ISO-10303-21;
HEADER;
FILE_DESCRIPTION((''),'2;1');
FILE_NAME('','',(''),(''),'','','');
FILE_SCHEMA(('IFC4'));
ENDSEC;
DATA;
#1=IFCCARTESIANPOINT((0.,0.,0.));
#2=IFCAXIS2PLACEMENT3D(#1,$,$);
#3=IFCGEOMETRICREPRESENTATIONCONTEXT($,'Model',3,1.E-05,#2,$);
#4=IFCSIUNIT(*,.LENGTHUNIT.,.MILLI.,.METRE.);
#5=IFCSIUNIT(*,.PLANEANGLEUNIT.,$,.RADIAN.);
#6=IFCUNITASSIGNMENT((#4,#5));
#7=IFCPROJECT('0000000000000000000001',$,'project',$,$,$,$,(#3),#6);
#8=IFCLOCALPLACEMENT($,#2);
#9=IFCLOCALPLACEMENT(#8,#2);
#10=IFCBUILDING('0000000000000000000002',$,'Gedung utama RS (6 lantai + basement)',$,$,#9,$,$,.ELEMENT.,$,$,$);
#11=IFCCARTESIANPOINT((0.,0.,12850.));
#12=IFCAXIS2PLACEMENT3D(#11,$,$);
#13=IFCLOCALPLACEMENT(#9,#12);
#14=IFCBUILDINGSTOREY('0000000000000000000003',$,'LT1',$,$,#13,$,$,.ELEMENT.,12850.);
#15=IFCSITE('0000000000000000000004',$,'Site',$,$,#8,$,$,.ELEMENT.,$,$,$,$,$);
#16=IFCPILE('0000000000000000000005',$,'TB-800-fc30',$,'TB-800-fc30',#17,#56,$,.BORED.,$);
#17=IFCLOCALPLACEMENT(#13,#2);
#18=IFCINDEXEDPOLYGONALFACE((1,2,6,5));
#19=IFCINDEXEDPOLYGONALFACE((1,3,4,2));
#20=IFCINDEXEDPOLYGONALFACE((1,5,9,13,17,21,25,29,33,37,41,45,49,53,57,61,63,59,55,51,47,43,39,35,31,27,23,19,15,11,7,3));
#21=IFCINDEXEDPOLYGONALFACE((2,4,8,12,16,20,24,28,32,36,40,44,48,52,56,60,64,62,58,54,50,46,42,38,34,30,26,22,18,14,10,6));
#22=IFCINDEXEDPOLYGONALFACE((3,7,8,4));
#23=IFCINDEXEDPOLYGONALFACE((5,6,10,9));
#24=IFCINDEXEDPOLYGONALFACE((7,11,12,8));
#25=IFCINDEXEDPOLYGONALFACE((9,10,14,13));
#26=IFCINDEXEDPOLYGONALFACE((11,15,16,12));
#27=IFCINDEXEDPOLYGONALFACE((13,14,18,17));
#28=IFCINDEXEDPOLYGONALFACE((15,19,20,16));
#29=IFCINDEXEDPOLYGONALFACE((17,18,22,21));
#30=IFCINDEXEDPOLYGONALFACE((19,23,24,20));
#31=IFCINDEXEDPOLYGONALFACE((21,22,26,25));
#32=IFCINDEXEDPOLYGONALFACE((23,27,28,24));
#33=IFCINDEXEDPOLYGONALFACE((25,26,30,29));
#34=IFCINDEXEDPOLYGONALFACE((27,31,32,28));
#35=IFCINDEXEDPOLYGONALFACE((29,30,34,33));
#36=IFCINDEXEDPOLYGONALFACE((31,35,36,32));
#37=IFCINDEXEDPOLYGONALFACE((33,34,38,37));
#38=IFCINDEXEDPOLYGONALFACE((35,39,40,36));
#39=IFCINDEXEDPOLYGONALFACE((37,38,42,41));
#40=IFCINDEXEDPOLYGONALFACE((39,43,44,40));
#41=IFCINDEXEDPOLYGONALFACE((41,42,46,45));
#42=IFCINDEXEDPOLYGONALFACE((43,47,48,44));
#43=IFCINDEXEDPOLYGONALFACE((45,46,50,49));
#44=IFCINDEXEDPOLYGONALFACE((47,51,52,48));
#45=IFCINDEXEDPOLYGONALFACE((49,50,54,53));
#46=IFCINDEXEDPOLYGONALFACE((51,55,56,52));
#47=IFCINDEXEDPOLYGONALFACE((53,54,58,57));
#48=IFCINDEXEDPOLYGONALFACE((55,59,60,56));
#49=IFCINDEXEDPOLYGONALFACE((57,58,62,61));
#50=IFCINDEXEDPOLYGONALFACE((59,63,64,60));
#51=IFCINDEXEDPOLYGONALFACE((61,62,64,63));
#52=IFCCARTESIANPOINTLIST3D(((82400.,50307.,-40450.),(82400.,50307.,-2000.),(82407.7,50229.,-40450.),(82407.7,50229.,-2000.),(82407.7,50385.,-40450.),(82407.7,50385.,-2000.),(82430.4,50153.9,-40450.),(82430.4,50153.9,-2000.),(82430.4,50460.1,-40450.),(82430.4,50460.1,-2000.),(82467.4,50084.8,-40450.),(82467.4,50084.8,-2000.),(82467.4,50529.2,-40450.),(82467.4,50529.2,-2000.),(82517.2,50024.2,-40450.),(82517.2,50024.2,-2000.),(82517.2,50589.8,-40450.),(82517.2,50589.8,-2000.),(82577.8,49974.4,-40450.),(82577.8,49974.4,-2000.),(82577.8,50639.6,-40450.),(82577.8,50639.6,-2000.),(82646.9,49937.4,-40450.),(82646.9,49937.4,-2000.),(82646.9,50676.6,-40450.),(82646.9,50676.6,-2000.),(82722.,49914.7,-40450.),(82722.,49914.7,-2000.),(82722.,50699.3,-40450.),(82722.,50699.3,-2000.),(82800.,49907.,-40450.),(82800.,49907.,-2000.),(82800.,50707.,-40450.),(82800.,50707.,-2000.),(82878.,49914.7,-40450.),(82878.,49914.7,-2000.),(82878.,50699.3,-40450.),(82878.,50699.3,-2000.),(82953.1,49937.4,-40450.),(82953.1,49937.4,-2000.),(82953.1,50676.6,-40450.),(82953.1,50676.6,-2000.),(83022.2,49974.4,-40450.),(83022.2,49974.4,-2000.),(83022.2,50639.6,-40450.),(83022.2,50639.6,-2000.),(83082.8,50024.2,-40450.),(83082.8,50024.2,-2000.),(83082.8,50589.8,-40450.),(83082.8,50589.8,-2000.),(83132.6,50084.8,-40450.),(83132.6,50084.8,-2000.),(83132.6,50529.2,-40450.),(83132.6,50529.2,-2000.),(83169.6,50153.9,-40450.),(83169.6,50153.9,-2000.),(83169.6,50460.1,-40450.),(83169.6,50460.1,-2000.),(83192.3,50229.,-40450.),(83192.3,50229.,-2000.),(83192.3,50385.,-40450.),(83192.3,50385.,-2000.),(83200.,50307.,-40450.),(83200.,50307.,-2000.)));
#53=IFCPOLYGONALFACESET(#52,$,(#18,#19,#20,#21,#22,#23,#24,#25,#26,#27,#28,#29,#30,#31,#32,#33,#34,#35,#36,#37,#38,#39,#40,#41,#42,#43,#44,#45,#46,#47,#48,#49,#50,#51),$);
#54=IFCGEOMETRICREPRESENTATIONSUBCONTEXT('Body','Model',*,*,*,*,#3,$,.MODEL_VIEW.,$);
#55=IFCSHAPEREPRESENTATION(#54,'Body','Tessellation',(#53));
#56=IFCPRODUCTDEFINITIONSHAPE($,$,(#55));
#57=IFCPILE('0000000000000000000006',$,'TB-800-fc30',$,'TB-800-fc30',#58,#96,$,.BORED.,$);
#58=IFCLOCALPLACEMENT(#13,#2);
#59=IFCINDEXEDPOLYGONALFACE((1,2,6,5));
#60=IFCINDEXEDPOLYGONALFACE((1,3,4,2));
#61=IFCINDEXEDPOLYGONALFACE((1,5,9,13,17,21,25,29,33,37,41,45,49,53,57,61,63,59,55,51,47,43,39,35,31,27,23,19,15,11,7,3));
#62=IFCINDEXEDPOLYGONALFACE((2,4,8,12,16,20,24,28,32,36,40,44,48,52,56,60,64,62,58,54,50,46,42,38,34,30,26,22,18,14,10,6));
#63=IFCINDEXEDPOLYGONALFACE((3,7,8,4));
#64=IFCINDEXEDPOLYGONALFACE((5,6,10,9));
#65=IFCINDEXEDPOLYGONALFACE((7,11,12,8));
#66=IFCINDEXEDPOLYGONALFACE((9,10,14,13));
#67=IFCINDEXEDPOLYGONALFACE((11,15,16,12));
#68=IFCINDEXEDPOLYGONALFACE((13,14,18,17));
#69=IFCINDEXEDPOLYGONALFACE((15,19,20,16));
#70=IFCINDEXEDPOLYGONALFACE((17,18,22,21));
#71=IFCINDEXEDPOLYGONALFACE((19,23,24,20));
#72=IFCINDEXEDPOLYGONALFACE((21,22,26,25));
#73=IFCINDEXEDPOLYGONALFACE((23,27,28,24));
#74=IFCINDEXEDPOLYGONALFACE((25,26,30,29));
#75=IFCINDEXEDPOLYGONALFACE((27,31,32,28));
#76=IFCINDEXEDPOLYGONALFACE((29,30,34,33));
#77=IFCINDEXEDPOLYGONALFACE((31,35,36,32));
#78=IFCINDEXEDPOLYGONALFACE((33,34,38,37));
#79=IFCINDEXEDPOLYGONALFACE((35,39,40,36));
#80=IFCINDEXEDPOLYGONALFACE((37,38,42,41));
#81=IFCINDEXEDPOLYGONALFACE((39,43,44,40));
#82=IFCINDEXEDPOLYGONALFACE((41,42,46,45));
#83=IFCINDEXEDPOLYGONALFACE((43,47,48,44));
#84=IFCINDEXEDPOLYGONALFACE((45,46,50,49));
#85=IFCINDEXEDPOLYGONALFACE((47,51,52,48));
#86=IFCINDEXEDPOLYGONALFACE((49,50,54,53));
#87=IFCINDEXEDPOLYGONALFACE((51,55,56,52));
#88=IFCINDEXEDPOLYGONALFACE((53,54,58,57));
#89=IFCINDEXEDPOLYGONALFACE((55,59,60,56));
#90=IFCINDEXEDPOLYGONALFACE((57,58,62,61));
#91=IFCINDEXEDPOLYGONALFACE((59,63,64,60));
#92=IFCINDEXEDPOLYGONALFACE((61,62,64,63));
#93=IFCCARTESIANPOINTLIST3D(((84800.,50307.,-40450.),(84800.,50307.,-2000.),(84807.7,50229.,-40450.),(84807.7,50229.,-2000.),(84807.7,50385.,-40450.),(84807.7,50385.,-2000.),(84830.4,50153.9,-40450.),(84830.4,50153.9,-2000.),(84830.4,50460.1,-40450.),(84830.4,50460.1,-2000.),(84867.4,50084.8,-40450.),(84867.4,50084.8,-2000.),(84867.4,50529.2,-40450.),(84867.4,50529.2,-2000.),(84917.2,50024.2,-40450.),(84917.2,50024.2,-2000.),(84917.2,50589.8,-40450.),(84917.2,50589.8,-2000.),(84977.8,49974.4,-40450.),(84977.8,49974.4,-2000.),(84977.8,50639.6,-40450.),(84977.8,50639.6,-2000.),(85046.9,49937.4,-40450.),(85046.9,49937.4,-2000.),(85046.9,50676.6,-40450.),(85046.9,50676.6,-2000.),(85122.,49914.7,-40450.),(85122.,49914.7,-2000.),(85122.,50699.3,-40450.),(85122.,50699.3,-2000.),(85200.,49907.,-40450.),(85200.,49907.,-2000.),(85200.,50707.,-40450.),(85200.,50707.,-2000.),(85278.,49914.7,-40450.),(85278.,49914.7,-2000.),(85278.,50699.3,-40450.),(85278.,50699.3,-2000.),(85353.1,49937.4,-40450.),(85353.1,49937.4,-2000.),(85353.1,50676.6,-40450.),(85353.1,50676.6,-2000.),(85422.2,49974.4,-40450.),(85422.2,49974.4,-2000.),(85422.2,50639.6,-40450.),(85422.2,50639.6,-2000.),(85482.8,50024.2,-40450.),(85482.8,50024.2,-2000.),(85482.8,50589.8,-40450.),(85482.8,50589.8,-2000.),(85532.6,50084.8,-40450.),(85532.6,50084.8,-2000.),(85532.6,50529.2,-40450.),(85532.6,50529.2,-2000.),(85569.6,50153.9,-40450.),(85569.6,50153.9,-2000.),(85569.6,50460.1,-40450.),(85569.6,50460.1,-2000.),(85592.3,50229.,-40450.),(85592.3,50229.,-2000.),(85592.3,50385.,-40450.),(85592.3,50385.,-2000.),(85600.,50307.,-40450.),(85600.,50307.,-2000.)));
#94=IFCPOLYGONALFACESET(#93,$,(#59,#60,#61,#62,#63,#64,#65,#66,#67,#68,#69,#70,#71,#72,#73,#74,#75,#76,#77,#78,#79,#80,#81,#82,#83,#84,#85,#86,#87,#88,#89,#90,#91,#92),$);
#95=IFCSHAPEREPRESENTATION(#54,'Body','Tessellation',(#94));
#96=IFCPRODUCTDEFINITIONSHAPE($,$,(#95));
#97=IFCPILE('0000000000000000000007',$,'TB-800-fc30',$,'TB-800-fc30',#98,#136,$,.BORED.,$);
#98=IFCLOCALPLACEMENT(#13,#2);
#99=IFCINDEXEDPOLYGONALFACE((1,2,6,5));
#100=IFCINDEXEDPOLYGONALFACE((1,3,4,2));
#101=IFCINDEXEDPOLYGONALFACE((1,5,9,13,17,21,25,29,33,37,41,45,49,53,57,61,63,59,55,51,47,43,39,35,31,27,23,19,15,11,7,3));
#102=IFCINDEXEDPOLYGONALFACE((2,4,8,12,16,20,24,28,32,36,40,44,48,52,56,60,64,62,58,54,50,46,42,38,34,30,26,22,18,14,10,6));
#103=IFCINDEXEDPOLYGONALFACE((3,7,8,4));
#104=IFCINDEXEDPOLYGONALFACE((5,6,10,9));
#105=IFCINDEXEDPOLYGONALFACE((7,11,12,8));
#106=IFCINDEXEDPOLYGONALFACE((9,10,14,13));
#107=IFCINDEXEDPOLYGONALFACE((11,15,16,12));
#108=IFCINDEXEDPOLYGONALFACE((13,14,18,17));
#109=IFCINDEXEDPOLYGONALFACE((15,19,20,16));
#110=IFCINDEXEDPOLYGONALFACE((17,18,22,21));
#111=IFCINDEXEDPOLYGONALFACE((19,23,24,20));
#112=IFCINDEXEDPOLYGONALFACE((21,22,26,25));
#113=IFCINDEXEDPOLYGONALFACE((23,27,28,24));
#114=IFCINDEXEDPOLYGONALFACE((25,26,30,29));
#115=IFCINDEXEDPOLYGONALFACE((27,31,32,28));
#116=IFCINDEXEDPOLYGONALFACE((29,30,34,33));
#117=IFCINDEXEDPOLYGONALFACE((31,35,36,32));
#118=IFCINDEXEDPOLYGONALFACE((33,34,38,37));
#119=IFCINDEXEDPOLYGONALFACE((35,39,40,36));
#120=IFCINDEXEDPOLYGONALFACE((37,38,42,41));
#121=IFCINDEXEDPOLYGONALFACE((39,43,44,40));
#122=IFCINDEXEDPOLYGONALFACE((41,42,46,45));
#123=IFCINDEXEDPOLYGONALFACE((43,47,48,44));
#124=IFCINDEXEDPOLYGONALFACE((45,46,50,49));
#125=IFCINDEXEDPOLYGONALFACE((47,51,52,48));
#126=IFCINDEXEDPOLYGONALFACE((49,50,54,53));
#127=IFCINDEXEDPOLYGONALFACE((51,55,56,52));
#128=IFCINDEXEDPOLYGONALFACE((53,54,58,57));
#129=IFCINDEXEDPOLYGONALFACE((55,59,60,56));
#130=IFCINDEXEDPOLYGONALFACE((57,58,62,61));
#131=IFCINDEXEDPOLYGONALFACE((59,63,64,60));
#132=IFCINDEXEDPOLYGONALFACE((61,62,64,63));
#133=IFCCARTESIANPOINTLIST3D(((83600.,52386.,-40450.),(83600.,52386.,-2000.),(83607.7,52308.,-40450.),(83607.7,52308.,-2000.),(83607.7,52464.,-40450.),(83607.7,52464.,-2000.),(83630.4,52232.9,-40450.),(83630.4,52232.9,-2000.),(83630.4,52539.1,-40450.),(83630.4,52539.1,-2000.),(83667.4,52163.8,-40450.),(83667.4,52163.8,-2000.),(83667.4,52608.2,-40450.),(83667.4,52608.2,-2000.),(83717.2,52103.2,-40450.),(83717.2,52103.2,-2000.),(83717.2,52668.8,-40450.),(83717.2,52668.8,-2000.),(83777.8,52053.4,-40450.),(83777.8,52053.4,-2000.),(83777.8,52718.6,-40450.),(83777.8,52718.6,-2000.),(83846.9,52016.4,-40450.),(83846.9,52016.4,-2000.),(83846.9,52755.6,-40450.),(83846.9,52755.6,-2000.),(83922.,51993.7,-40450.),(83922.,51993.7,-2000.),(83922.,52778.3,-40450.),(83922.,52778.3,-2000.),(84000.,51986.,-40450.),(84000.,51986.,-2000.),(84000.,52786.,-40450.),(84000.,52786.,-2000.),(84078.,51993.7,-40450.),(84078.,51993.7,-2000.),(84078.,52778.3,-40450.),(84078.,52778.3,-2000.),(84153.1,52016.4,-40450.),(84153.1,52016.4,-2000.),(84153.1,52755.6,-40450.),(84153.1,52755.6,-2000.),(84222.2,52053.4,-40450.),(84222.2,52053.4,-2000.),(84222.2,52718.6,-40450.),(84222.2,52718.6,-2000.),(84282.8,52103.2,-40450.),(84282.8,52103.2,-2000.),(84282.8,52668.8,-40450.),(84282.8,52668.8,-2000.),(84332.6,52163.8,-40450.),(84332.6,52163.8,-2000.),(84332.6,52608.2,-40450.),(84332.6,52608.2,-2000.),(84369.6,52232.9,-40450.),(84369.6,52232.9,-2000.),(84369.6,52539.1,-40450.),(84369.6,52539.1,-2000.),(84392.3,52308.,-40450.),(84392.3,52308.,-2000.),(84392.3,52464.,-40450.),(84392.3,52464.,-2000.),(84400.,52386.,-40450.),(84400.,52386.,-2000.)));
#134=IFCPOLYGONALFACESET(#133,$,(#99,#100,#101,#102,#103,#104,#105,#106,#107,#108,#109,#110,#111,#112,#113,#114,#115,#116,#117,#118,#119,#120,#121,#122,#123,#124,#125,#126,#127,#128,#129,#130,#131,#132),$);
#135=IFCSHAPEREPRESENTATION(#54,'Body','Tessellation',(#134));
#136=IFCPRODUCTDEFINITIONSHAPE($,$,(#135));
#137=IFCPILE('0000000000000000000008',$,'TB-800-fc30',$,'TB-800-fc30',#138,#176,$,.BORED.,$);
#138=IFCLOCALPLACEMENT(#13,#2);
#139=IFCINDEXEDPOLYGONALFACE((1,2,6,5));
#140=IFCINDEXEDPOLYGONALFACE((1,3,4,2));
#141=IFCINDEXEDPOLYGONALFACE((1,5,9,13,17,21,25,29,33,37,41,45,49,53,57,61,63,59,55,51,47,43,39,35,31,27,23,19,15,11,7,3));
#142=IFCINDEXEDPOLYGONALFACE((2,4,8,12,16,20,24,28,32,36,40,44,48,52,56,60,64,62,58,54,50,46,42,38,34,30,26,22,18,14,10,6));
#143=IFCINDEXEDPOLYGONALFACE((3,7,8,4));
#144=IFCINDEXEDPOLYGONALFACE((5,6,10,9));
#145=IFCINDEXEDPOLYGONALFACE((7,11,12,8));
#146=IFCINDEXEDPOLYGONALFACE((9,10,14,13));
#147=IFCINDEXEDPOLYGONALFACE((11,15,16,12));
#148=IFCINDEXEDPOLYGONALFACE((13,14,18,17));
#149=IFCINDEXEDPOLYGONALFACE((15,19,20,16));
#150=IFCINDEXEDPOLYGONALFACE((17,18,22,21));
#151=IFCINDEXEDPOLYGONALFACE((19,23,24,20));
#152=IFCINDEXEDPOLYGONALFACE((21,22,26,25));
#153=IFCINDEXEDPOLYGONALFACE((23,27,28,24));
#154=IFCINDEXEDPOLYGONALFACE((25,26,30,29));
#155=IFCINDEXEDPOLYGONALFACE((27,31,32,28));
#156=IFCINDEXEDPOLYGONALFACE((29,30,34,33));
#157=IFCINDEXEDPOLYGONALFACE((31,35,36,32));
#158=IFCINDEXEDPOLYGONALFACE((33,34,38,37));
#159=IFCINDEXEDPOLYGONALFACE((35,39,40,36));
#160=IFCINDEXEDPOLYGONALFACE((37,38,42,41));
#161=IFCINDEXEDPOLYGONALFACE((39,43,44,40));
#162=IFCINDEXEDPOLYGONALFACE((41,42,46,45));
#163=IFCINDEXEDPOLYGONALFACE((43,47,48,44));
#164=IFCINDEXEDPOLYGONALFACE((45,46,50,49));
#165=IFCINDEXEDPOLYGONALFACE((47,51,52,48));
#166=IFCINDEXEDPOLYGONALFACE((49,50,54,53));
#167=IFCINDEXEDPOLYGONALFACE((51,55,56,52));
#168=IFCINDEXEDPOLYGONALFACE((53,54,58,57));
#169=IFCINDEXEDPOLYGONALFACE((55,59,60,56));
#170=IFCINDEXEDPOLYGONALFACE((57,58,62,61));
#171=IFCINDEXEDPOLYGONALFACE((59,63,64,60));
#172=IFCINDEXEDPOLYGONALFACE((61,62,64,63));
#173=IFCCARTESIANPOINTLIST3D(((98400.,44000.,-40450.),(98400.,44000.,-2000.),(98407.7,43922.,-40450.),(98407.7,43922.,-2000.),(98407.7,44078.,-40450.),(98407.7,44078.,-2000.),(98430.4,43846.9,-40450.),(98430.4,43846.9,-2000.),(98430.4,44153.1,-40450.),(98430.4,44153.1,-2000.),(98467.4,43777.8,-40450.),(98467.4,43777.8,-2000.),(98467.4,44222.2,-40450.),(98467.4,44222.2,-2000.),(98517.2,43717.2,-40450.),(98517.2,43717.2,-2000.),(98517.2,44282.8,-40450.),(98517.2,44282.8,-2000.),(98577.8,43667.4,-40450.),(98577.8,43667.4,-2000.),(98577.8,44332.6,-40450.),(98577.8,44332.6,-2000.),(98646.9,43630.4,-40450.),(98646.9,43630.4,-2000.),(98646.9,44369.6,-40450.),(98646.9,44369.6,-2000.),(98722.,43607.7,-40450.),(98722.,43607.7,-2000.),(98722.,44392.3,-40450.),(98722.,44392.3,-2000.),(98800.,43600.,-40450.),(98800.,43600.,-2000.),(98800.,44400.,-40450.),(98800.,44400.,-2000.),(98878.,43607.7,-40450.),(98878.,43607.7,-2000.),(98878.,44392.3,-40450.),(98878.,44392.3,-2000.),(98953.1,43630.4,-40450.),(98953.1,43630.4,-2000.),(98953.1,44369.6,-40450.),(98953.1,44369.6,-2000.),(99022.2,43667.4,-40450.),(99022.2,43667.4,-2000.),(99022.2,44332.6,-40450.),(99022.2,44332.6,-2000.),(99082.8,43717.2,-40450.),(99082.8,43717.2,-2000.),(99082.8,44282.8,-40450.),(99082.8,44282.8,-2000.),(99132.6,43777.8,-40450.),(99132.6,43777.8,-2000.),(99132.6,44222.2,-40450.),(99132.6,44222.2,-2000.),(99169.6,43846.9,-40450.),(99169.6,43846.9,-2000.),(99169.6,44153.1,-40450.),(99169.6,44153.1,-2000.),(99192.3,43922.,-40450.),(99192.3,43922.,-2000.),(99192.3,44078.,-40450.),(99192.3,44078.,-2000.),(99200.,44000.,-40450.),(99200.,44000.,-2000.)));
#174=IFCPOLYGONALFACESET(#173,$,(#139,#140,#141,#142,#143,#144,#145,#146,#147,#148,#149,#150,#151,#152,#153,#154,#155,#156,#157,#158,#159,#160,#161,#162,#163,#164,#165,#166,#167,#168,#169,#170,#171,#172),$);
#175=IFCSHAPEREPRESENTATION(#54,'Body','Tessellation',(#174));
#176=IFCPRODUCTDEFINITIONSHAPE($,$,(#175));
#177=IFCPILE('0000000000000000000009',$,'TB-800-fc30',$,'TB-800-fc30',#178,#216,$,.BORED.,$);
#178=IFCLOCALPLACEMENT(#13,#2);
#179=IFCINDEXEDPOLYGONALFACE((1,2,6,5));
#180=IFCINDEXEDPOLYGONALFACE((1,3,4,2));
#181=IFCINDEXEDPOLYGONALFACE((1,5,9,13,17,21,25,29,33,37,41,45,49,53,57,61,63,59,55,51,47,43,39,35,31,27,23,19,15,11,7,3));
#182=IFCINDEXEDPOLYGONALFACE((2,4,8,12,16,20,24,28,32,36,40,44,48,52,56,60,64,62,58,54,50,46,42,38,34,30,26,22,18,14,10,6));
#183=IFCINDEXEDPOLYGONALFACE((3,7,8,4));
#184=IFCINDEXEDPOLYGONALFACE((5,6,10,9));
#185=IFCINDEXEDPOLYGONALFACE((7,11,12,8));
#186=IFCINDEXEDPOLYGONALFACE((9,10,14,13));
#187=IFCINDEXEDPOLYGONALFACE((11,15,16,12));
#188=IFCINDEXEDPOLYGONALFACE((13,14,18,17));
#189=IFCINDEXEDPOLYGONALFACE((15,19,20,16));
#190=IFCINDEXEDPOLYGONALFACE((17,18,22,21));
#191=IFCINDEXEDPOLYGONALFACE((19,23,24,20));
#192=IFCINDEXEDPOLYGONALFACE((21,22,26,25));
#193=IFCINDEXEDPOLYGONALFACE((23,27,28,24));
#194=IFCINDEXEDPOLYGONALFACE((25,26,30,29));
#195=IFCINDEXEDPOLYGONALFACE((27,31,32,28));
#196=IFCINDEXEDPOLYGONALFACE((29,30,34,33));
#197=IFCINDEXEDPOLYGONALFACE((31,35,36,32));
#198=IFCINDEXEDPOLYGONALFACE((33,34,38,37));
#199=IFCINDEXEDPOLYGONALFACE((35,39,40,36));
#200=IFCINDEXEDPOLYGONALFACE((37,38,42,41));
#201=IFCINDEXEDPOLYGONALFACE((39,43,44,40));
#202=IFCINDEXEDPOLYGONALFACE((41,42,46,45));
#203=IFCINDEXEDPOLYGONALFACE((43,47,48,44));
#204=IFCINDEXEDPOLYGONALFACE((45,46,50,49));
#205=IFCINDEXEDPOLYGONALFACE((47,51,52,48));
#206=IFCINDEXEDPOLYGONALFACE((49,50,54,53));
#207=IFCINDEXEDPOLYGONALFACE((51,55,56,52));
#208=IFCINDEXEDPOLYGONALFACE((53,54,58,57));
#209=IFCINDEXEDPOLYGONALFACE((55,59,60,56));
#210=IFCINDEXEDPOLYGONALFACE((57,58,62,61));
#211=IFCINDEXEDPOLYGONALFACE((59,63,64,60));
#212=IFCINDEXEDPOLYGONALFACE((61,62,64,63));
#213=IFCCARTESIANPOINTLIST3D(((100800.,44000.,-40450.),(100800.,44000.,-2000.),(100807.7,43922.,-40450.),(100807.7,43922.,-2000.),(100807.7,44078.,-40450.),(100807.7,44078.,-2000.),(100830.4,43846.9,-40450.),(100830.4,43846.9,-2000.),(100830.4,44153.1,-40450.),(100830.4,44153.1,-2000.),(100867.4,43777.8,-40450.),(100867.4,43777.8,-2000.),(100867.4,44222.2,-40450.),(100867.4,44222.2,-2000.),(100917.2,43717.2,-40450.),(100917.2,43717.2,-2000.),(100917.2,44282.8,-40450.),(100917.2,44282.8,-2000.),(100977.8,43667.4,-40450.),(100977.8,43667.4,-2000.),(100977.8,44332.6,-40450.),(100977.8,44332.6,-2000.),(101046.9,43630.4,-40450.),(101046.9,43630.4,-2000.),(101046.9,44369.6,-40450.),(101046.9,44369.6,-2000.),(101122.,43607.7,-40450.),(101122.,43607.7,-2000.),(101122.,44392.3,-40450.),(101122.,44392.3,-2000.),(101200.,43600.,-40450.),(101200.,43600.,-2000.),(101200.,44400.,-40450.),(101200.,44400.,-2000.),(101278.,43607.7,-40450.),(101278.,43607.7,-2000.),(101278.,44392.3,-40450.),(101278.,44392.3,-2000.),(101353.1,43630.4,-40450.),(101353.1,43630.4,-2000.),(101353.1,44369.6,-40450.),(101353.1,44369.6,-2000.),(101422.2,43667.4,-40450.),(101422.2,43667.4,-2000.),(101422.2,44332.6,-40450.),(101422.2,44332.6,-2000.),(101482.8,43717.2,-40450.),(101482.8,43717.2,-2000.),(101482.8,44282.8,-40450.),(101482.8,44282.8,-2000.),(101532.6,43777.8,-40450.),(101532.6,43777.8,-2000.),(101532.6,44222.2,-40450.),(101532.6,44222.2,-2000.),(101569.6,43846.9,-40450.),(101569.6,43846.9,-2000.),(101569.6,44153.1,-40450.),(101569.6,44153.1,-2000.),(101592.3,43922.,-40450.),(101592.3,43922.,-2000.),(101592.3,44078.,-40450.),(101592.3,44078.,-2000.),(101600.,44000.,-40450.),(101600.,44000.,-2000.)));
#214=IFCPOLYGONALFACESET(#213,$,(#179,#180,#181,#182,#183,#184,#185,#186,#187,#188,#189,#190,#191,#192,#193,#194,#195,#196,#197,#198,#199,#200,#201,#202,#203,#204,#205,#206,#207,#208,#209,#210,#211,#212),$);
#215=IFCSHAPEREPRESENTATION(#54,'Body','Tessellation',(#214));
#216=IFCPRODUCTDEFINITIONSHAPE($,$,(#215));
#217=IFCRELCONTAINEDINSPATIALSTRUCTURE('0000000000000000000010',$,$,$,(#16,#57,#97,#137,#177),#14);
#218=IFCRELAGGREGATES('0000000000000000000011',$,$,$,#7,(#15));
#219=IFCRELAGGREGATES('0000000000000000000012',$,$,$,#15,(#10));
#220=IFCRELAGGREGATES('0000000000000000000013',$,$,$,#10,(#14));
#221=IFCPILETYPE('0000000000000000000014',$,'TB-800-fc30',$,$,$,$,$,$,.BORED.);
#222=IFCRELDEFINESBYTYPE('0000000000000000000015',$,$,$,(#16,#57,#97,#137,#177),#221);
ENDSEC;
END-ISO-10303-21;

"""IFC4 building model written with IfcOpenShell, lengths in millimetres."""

from ifc_helpers import new_model, si_unit, frame, origin, origin_2d, place, context, subcontext, project, spatial, circle, extrude, material_profile, profile_set, profile_usage, type_object, element, save


model = new_model("IFC4")

# Units and contexts
model_context = context("Model", 3, precision=1e-05, world=origin())
body_context = subcontext(model_context, "Body", "Model", "MODEL_VIEW")
ifc_project = project(units=[si_unit("LENGTHUNIT", "METRE", prefix="MILLI"), si_unit("PLANEANGLEUNIT", "RADIAN")], contexts=[model_context])

# Site, building, storey
site_placement = place(None, origin())
site = spatial("IfcSite", under=ifc_project, at=site_placement, Name="Site", CompositionType="ELEMENT")
building_placement = place(site_placement, origin())
building = spatial("IfcBuilding", under=site, at=building_placement, Name="Gedung utama RS (6 lantai + basement)", CompositionType="ELEMENT")
storey_placement = place(building_placement, frame((0.0, 0.0, 12850.0)))
storey = spatial("IfcBuildingStorey", under=building, at=storey_placement, Name="LT1", CompositionType="ELEMENT", Elevation=12850.0)

# Piles
ifc_material_profile_1 = material_profile(None, circle(Radius=400.0, at=origin_2d()), Name="TB-800-fc30")
ifc_profile_set_1 = profile_set([ifc_material_profile_1], Name="TB-800-fc30")
ifc_profile_usage_1 = profile_usage(ifc_profile_set_1, cardinal=5)
pile_type = type_object("IfcPileType", Name="TB-800-fc30", PredefinedType="BORED", material=ifc_profile_set_1)
for number, where, z_axis, x_axis, name in (
    (1, (82800.0, 50307.0, -40450.0), (0.0, 0.0, 1.0), (1.0, 0.0, 0.0), "TB-800-fc30"),
    (2, (85200.0, 50307.0, -40450.0), (0.0, 0.0, 1.0), (1.0, 0.0, 0.0), "TB-800-fc30"),
    (3, (84000.0, 52386.0, -40450.0), (0.0, 0.0, 1.0), (1.0, 0.0, 0.0), "TB-800-fc30"),
    (4, (98800.0, 44000.0, -40450.0), (0.0, 0.0, 1.0), (1.0, 0.0, 0.0), "TB-800-fc30"),
    (5, (101200.0, 44000.0, -40450.0), (0.0, 0.0, 1.0), (1.0, 0.0, 0.0), "TB-800-fc30"),
):
    element("IfcPile", number, at=place(storey_placement, frame(where, z_axis=z_axis, x_axis=x_axis)), inside=storey, type_object=pile_type, material=ifc_profile_usage_1, Name=name, ObjectType="TB-800-fc30", PredefinedType="BORED", context=body_context, shape_type="SweptSolid", body=[
        extrude(circle(Radius=400.0, at=origin_2d()), origin(), (0.0, 0.0, 1.0), 38450.0),
    ])

save(model, "model.ifc")
